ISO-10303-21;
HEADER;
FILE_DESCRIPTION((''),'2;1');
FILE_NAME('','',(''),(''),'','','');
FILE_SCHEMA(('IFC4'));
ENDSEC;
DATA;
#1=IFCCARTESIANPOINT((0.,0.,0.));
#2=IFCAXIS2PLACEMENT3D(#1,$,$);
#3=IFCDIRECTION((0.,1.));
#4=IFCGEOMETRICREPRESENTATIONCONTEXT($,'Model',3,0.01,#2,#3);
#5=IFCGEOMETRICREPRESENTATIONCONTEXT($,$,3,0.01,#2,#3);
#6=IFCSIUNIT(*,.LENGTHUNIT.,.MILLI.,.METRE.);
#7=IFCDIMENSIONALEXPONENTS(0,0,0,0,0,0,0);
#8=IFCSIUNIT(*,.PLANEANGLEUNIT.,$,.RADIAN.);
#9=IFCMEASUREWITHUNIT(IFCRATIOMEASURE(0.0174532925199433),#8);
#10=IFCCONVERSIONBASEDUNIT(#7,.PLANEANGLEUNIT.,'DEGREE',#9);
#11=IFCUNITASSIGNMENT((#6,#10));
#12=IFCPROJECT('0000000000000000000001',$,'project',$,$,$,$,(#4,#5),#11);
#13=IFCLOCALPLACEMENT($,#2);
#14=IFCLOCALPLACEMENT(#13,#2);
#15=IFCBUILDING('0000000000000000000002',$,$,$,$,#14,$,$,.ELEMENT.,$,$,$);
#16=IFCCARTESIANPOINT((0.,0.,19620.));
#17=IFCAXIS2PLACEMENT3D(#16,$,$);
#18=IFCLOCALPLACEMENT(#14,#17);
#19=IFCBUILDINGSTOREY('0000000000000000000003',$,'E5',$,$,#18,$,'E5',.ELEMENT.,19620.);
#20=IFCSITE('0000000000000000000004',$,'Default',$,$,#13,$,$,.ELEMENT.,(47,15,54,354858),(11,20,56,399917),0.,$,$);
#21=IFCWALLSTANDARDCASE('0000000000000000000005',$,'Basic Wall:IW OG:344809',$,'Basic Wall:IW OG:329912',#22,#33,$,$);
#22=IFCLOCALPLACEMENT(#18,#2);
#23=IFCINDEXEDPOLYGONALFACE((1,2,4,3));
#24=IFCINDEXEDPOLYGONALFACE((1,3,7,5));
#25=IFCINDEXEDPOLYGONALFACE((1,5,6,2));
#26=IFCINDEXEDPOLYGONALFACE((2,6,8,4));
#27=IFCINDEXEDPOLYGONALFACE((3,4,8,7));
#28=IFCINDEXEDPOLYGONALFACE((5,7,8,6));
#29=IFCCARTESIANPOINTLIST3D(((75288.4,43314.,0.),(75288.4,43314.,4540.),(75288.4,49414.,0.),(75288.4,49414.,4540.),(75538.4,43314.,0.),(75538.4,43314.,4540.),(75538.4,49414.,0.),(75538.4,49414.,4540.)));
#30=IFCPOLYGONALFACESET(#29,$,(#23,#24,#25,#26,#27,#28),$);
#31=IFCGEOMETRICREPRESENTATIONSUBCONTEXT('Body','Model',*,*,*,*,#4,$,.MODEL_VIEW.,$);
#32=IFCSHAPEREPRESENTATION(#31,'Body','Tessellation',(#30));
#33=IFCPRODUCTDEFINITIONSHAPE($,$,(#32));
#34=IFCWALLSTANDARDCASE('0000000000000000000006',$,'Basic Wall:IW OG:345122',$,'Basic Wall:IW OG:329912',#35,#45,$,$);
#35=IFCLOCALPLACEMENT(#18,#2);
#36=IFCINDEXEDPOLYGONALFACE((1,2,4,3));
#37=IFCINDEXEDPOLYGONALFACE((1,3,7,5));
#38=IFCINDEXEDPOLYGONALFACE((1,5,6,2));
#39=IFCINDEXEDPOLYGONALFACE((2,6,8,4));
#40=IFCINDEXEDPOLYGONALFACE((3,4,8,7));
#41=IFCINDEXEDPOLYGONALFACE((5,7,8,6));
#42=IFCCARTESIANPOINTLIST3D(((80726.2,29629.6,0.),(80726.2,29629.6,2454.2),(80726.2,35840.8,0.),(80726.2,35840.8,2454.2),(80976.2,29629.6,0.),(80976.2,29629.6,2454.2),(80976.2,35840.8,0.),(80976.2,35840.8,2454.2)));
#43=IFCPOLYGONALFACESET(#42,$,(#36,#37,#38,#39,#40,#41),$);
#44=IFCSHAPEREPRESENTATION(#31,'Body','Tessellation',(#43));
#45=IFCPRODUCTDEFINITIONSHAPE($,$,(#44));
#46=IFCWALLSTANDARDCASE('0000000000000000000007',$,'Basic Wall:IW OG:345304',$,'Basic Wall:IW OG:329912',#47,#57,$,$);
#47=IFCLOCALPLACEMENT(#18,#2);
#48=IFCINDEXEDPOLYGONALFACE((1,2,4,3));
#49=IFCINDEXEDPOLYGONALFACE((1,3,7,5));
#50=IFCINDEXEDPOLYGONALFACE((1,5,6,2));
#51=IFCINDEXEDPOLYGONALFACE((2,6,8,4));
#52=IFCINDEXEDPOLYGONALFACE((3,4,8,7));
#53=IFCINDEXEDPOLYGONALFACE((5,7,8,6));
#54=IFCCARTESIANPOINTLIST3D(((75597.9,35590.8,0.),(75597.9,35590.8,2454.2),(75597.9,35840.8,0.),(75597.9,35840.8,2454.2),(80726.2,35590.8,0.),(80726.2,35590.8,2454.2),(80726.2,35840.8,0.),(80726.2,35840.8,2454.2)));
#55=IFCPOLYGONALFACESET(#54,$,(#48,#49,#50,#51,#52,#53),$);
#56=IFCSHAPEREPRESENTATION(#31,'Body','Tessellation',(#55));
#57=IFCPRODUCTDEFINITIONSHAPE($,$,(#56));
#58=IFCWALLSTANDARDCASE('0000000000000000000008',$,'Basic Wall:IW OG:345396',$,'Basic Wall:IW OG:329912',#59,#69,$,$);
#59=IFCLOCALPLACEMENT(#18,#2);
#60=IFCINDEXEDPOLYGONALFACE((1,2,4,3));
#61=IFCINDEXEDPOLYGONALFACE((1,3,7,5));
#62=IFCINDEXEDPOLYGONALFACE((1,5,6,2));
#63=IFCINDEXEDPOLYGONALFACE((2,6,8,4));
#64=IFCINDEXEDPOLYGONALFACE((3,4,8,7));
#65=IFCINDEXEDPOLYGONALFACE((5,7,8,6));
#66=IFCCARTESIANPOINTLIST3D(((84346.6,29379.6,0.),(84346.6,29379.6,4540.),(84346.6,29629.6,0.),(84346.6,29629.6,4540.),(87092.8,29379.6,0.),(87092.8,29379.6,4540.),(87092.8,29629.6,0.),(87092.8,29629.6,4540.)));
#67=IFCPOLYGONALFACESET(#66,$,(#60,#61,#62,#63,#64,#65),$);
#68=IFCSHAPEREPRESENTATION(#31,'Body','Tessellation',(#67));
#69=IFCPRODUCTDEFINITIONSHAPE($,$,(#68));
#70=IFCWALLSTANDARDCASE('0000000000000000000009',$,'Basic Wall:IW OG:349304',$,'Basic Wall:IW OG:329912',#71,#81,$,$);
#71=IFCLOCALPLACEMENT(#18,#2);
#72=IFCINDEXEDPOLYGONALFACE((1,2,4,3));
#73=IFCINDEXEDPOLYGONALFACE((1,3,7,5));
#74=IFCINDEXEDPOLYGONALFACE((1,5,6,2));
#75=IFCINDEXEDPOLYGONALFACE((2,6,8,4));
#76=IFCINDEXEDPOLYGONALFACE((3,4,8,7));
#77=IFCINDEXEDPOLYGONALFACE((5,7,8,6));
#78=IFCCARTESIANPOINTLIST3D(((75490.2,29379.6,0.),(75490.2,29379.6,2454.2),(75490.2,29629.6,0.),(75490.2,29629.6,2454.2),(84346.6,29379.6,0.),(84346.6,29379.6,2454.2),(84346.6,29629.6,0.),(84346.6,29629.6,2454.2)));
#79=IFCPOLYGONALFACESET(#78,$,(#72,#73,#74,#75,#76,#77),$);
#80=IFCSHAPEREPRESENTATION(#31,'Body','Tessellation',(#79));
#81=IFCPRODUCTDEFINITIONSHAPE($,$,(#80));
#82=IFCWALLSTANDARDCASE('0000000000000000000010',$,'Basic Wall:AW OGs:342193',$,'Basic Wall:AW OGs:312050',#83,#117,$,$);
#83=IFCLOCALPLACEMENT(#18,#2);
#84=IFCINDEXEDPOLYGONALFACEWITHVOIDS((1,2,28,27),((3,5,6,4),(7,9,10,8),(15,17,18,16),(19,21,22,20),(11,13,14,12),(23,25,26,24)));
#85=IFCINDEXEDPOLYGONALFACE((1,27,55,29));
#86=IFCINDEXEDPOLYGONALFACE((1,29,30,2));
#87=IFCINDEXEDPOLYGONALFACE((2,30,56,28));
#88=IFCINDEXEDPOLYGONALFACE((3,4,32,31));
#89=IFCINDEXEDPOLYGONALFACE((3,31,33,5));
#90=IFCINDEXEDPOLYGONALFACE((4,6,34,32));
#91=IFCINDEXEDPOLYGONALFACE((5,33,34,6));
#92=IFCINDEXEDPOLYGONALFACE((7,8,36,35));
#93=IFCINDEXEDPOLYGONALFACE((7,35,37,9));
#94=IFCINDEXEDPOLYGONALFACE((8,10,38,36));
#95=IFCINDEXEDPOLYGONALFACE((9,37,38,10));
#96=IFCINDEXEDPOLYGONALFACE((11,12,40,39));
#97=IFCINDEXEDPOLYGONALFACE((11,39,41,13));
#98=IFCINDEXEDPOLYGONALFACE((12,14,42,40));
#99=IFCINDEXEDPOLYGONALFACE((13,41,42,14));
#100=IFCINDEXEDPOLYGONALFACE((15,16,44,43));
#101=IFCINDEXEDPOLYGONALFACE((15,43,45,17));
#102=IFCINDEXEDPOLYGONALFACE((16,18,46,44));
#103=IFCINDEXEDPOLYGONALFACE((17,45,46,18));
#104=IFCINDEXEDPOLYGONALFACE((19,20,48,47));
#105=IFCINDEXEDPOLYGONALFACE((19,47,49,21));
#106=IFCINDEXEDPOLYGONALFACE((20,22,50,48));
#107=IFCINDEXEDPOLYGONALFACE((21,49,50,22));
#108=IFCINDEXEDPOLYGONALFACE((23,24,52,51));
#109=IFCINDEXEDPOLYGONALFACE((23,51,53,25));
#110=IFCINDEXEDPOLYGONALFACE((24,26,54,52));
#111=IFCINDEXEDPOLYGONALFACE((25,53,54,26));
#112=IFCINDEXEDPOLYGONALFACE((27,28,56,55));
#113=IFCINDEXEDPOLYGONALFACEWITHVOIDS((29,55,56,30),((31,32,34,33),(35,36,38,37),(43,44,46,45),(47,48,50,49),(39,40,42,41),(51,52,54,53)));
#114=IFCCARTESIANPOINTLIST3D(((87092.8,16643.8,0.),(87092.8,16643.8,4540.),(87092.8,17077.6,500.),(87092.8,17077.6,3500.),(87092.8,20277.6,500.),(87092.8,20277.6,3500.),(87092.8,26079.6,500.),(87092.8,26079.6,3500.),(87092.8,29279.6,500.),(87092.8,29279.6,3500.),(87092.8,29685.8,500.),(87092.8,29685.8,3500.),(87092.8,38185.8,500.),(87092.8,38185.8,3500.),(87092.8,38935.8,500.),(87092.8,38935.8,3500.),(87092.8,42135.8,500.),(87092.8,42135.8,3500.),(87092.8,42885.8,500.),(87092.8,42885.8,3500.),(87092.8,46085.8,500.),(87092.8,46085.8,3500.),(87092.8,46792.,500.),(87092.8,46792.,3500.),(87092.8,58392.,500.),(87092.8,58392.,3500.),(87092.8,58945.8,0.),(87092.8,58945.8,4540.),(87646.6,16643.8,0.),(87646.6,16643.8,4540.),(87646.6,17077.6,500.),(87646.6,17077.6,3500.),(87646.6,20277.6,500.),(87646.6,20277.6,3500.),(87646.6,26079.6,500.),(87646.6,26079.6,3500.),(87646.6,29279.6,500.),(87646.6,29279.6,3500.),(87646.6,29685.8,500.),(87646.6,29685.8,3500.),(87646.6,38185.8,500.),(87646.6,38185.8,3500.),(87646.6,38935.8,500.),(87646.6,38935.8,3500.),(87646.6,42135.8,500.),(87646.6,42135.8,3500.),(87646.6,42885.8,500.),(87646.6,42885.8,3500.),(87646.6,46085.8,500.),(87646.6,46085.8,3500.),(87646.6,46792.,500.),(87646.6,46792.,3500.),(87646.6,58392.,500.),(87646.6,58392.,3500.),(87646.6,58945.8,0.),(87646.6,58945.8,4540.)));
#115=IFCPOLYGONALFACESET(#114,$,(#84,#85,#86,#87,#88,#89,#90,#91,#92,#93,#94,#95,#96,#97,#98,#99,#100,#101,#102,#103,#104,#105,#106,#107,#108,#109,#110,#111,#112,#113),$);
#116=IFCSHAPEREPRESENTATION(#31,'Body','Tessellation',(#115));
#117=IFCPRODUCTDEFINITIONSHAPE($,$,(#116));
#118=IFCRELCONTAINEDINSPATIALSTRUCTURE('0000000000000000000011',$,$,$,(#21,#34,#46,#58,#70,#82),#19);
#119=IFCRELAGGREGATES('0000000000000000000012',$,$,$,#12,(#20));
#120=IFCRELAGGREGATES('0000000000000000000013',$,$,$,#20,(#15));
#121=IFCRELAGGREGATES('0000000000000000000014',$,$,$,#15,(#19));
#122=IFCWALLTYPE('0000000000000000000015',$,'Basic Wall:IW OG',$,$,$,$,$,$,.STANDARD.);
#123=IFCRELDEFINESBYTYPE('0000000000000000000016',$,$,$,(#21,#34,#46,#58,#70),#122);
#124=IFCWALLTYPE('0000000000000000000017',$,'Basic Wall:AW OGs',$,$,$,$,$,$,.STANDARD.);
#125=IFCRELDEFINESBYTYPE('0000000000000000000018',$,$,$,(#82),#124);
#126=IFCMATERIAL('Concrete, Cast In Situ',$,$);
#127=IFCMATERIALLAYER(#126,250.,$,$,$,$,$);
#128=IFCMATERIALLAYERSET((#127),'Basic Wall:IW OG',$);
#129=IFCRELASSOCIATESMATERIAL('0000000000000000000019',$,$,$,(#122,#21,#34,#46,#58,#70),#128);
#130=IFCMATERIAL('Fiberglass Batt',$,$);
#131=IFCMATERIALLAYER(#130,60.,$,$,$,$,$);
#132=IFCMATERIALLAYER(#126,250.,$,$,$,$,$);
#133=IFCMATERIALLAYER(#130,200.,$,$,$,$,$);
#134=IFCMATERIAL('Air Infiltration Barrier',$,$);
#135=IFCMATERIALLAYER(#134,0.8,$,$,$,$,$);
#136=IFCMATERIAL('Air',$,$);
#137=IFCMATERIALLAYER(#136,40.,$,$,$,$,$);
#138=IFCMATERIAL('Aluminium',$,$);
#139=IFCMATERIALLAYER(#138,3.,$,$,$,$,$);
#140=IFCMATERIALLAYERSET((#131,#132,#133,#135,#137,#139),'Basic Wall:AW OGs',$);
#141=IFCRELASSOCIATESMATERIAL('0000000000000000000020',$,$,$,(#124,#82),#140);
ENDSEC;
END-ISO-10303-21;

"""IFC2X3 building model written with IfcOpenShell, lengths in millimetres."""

from ifc_helpers import new_model, entity, si_unit, converted_unit, direction, frame, frame_2d, origin, place, context, subcontext, project, spatial, polyline, rectangle, extrude, clip, bounded_halfspace, material, layer, layer_set, layer_usage, type_object, element, save


model = new_model("IFC2X3")

# Units and contexts
model_context = context("Model", 3, precision=0.01, world=origin(), true_north=direction((0.0, 1.0)))
context_of_model = context(None, 3, precision=0.01, world=origin(), true_north=direction((0.0, 1.0)))
body_context = subcontext(model_context, "Body", "Model", "MODEL_VIEW")
ifc_project = project(units=[si_unit("LENGTHUNIT", "METRE", prefix="MILLI"), converted_unit("PLANEANGLEUNIT", "DEGREE", entity("IfcRatioMeasure", 0.0174532925199433), si_unit("PLANEANGLEUNIT", "RADIAN"), dimensions=[0, 0, 0, 0, 0, 0, 0])], contexts=[model_context, context_of_model])

# Site, building, storey
site_placement = place(None, origin())
site = spatial("IfcSite", under=ifc_project, at=site_placement, Name="Default", CompositionType="ELEMENT", RefLatitude=(47, 15, 54, 354858), RefLongitude=(11, 20, 56, 399917), RefElevation=0.0)
building_placement = place(site_placement, origin())
building = spatial("IfcBuilding", under=site, at=building_placement, CompositionType="ELEMENT")
storey_placement = place(building_placement, frame((0.0, 0.0, 19620.0)))
storey = spatial("IfcBuildingStorey", under=building, at=storey_placement, Name="E5", LongName="E5", CompositionType="ELEMENT", Elevation=19620.0)

# Walls
ifc_material_1 = material(Name="Concrete, Cast In Situ")
ifc_layer_1 = layer(ifc_material_1, 250.0)
ifc_layer_set_1 = layer_set([ifc_layer_1], Name="Basic Wall:IW OG")
ifc_layer_usage_1 = layer_usage(ifc_layer_set_1, "AXIS2", "NEGATIVE", 125.0)
wall_type_1 = type_object("IfcWallType", Name="Basic Wall:IW OG", PredefinedType="STANDARD", material=ifc_layer_set_1)
wall_1_placement = place(storey_placement, frame((75413.4, 49414.0, 0.0), z_axis=(0.0, 0.0, 1.0), x_axis=(0.0, -1.0, 0.0)))
element("IfcWallStandardCase", 1, at=wall_1_placement, inside=storey, type_object=wall_type_1, material=ifc_layer_usage_1, Name="Basic Wall:IW OG:344809", ObjectType="Basic Wall:IW OG:329912", context=body_context, shape_type="SweptSolid", body=[
    extrude(rectangle(XDim=6100.0, YDim=250.0, at=frame_2d((3050.0, 0.0), x_axis=(-1.0, 0.0))), origin(), (0.0, 0.0, 1.0), 4540.0),
])
ifc_layer_usage_2 = layer_usage(ifc_layer_set_1, "AXIS2", "NEGATIVE", 125.0)
wall_2_placement = place(storey_placement, frame((80851.2, 29629.6, 0.0), z_axis=(0.0, 0.0, 1.0), x_axis=(0.0, 1.0, 0.0)))
element("IfcWallStandardCase", 2, at=wall_2_placement, inside=storey, type_object=wall_type_1, material=ifc_layer_usage_2, Name="Basic Wall:IW OG:345122", ObjectType="Basic Wall:IW OG:329912", context=body_context, shape_type="Clipping", body=[
    clip(extrude(rectangle(XDim=6211.2, YDim=250.0, at=frame_2d((3105.6, 0.0), x_axis=(-1.0, 0.0))), origin(), (0.0, 0.0, 1.0), 2454.2), bounded_halfspace(frame((0.0, -125.0, 2454.2), z_axis=(0.0, 0.0, -1.0), x_axis=(0.0, 1.0, 0.0)), True, frame((0.0, -125.0, 2454.2)), polyline([(0.0, 0.0), (6211.2, 0.0), (6211.2, 250.0), (5961.2, 250.0), (0.0, 250.0), (0.0, 0.0)]))),
])
ifc_layer_usage_3 = layer_usage(ifc_layer_set_1, "AXIS2", "NEGATIVE", 125.0)
wall_3_placement = place(storey_placement, frame((80726.2, 35715.8, 0.0), z_axis=(0.0, 0.0, 1.0), x_axis=(-1.0, 0.0, 0.0)))
element("IfcWallStandardCase", 3, at=wall_3_placement, inside=storey, type_object=wall_type_1, material=ifc_layer_usage_3, Name="Basic Wall:IW OG:345304", ObjectType="Basic Wall:IW OG:329912", context=body_context, shape_type="Clipping", body=[
    clip(extrude(rectangle(XDim=5128.3, YDim=250.0, at=frame_2d((2564.2, 0.0), x_axis=(-1.0, 0.0))), origin(), (0.0, 0.0, 1.0), 2454.2), bounded_halfspace(frame((0.0, -125.0, 2454.2), z_axis=(0.0, 0.0, -1.0), x_axis=(1.0, 0.0, 0.0)), True, frame((0.0, -125.0, 2454.2)), polyline([(0.0, 0.0), (5128.3, 0.0), (5128.3, 250.0), (0.0, 250.0), (0.0, 0.0)]))),
])
ifc_layer_usage_4 = layer_usage(ifc_layer_set_1, "AXIS2", "NEGATIVE", 125.0)
wall_4_placement = place(storey_placement, frame((87092.8, 29504.6, 0.0), z_axis=(0.0, 0.0, 1.0), x_axis=(-1.0, 0.0, 0.0)))
element("IfcWallStandardCase", 4, at=wall_4_placement, inside=storey, type_object=wall_type_1, material=ifc_layer_usage_4, Name="Basic Wall:IW OG:345396", ObjectType="Basic Wall:IW OG:329912", context=body_context, shape_type="SweptSolid", body=[
    extrude(rectangle(XDim=2746.2, YDim=250.0, at=frame_2d((1373.1, 0.0), x_axis=(-1.0, 0.0))), origin(), (0.0, 0.0, 1.0), 4540.0),
])
ifc_layer_usage_5 = layer_usage(ifc_layer_set_1, "AXIS2", "NEGATIVE", 125.0)
wall_5_placement = place(storey_placement, frame((84346.6, 29504.6, 0.0), z_axis=(0.0, 0.0, 1.0), x_axis=(-1.0, 0.0, 0.0)))
element("IfcWallStandardCase", 5, at=wall_5_placement, inside=storey, type_object=wall_type_1, material=ifc_layer_usage_5, Name="Basic Wall:IW OG:349304", ObjectType="Basic Wall:IW OG:329912", context=body_context, shape_type="Clipping", body=[
    clip(extrude(rectangle(XDim=8856.4, YDim=250.0, at=frame_2d((4428.2, 0.0), x_axis=(-1.0, 0.0))), origin(), (0.0, 0.0, 1.0), 2454.2), bounded_halfspace(frame((0.0, -125.0, 2454.2), z_axis=(0.0, 0.0, -1.0), x_axis=(1.0, 0.0, 0.0)), True, frame((0.0, -125.0, 2454.2)), polyline([(0.0, 0.0), (3370.4, 0.0), (3620.4, 0.0), (8808.8, 0.0), (8808.8, 250.0), (0.0, 250.0), (0.0, 0.0)]))),
])

# Wall, openings
ifc_material_2 = material(Name="Fiberglass Batt")
ifc_layer_2 = layer(ifc_material_2, 60.0)
ifc_layer_3 = layer(ifc_material_1, 250.0)
ifc_layer_4 = layer(ifc_material_2, 200.0)
ifc_material_3 = material(Name="Air Infiltration Barrier")
ifc_layer_5 = layer(ifc_material_3, 0.8)
ifc_material_4 = material(Name="Air")
ifc_layer_6 = layer(ifc_material_4, 40.0)
ifc_material_5 = material(Name="Aluminium")
ifc_layer_7 = layer(ifc_material_5, 3.0)
ifc_layer_set_2 = layer_set([ifc_layer_2, ifc_layer_3, ifc_layer_4, ifc_layer_5, ifc_layer_6, ifc_layer_7], Name="Basic Wall:AW OGs")
ifc_layer_usage_6 = layer_usage(ifc_layer_set_2, "AXIS2", "NEGATIVE", 276.9)
wall_type_2 = type_object("IfcWallType", Name="Basic Wall:AW OGs", PredefinedType="STANDARD", material=ifc_layer_set_2)
wall_6_placement = place(storey_placement, frame((87369.7, 16643.8, 0.0), z_axis=(0.0, 0.0, 1.0), x_axis=(0.0, 1.0, 0.0)))
wall_6 = element("IfcWallStandardCase", 6, at=wall_6_placement, inside=storey, type_object=wall_type_2, material=ifc_layer_usage_6, Name="Basic Wall:AW OGs:342193", ObjectType="Basic Wall:AW OGs:312050", context=body_context, shape_type="SweptSolid", body=[
    extrude(rectangle(XDim=42302.0, YDim=553.8, at=frame_2d((21151.0, 0.0), x_axis=(-1.0, 0.0))), origin(), (0.0, 0.0, 1.0), 4540.0),
])
opening_1_placement = place(wall_6_placement, origin())
element("IfcOpeningElement", 7, at=opening_1_placement, cuts=wall_6, ObjectType="Opening", context=body_context, shape_type="SweptSolid", body=[
    extrude(rectangle(XDim=3000.0, YDim=553.8, at=frame_2d((0.0, 0.0), x_axis=(0.0, 1.0))), frame((42025.1, 276.9, 2000.0), z_axis=(0.0, 1.0, 0.0), x_axis=(1.0, 0.0, 0.0)), (0.0, 0.0, 1.0), 11600.0),
])
opening_2_placement = place(wall_6_placement, frame((41748.2, 276.9, 500.0)))
element("IfcOpeningElement", 8, at=opening_2_placement, cuts=wall_6, ObjectType="Opening", context=body_context, shape_type="SweptSolid", body=[
    extrude(rectangle(XDim=3000.0, YDim=11600.0, at=frame_2d((1500.0, 5800.0), x_axis=(-1.0, 0.0))), frame((0.0, 0.0, 0.0), z_axis=(0.0, -1.0, 0.0), x_axis=(0.0, 0.0, 1.0)), (0.0, 0.0, 1.0), 553.8),
])
opening_3_placement = place(wall_6_placement, frame((21542.0, 276.9, 500.0)))
element("IfcOpeningElement", 9, at=opening_3_placement, cuts=wall_6, ObjectType="Opening", context=body_context, shape_type="SweptSolid", body=[
    extrude(rectangle(XDim=3000.0, YDim=8500.0, at=frame_2d((1500.0, 4250.0), x_axis=(-1.0, 0.0))), frame((0.0, 0.0, 0.0), z_axis=(0.0, -1.0, 0.0), x_axis=(0.0, 0.0, 1.0)), (0.0, 0.0, 1.0), 553.8),
])
opening_4_placement = place(wall_6_placement, frame((3633.8, 276.9, 500.0)))
element("IfcOpeningElement", 10, at=opening_4_placement, cuts=wall_6, ObjectType="Opening", context=body_context, shape_type="SweptSolid", body=[
    extrude(rectangle(XDim=3000.0, YDim=3200.0, at=frame_2d((1500.0, 1600.0), x_axis=(-1.0, 0.0))), frame((0.0, 0.0, 0.0), z_axis=(0.0, -1.0, 0.0), x_axis=(0.0, 0.0, 1.0)), (0.0, 0.0, 1.0), 553.8),
])
opening_5_placement = place(wall_6_placement, frame((12635.8, 276.9, 500.0)))
element("IfcOpeningElement", 11, at=opening_5_placement, cuts=wall_6, ObjectType="Opening", context=body_context, shape_type="SweptSolid", body=[
    extrude(rectangle(XDim=3000.0, YDim=3200.0, at=frame_2d((1500.0, 1600.0), x_axis=(-1.0, 0.0))), frame((0.0, 0.0, 0.0), z_axis=(0.0, -1.0, 0.0), x_axis=(0.0, 0.0, 1.0)), (0.0, 0.0, 1.0), 553.8),
])
opening_6_placement = place(wall_6_placement, frame((29442.0, 276.9, 500.0)))
element("IfcOpeningElement", 12, at=opening_6_placement, cuts=wall_6, ObjectType="Opening", context=body_context, shape_type="SweptSolid", body=[
    extrude(rectangle(XDim=3000.0, YDim=3200.0, at=frame_2d((1500.0, 1600.0), x_axis=(-1.0, 0.0))), frame((0.0, 0.0, 0.0), z_axis=(0.0, -1.0, 0.0), x_axis=(0.0, 0.0, 1.0)), (0.0, 0.0, 1.0), 553.8),
])
opening_7_placement = place(wall_6_placement, frame((25492.0, 276.9, 500.0)))
element("IfcOpeningElement", 13, at=opening_7_placement, cuts=wall_6, ObjectType="Opening", context=body_context, shape_type="SweptSolid", body=[
    extrude(rectangle(XDim=3000.0, YDim=3200.0, at=frame_2d((1500.0, 1600.0), x_axis=(-1.0, 0.0))), frame((0.0, 0.0, 0.0), z_axis=(0.0, -1.0, 0.0), x_axis=(0.0, 0.0, 1.0)), (0.0, 0.0, 1.0), 553.8),
])

save(model, "model.ifc")
